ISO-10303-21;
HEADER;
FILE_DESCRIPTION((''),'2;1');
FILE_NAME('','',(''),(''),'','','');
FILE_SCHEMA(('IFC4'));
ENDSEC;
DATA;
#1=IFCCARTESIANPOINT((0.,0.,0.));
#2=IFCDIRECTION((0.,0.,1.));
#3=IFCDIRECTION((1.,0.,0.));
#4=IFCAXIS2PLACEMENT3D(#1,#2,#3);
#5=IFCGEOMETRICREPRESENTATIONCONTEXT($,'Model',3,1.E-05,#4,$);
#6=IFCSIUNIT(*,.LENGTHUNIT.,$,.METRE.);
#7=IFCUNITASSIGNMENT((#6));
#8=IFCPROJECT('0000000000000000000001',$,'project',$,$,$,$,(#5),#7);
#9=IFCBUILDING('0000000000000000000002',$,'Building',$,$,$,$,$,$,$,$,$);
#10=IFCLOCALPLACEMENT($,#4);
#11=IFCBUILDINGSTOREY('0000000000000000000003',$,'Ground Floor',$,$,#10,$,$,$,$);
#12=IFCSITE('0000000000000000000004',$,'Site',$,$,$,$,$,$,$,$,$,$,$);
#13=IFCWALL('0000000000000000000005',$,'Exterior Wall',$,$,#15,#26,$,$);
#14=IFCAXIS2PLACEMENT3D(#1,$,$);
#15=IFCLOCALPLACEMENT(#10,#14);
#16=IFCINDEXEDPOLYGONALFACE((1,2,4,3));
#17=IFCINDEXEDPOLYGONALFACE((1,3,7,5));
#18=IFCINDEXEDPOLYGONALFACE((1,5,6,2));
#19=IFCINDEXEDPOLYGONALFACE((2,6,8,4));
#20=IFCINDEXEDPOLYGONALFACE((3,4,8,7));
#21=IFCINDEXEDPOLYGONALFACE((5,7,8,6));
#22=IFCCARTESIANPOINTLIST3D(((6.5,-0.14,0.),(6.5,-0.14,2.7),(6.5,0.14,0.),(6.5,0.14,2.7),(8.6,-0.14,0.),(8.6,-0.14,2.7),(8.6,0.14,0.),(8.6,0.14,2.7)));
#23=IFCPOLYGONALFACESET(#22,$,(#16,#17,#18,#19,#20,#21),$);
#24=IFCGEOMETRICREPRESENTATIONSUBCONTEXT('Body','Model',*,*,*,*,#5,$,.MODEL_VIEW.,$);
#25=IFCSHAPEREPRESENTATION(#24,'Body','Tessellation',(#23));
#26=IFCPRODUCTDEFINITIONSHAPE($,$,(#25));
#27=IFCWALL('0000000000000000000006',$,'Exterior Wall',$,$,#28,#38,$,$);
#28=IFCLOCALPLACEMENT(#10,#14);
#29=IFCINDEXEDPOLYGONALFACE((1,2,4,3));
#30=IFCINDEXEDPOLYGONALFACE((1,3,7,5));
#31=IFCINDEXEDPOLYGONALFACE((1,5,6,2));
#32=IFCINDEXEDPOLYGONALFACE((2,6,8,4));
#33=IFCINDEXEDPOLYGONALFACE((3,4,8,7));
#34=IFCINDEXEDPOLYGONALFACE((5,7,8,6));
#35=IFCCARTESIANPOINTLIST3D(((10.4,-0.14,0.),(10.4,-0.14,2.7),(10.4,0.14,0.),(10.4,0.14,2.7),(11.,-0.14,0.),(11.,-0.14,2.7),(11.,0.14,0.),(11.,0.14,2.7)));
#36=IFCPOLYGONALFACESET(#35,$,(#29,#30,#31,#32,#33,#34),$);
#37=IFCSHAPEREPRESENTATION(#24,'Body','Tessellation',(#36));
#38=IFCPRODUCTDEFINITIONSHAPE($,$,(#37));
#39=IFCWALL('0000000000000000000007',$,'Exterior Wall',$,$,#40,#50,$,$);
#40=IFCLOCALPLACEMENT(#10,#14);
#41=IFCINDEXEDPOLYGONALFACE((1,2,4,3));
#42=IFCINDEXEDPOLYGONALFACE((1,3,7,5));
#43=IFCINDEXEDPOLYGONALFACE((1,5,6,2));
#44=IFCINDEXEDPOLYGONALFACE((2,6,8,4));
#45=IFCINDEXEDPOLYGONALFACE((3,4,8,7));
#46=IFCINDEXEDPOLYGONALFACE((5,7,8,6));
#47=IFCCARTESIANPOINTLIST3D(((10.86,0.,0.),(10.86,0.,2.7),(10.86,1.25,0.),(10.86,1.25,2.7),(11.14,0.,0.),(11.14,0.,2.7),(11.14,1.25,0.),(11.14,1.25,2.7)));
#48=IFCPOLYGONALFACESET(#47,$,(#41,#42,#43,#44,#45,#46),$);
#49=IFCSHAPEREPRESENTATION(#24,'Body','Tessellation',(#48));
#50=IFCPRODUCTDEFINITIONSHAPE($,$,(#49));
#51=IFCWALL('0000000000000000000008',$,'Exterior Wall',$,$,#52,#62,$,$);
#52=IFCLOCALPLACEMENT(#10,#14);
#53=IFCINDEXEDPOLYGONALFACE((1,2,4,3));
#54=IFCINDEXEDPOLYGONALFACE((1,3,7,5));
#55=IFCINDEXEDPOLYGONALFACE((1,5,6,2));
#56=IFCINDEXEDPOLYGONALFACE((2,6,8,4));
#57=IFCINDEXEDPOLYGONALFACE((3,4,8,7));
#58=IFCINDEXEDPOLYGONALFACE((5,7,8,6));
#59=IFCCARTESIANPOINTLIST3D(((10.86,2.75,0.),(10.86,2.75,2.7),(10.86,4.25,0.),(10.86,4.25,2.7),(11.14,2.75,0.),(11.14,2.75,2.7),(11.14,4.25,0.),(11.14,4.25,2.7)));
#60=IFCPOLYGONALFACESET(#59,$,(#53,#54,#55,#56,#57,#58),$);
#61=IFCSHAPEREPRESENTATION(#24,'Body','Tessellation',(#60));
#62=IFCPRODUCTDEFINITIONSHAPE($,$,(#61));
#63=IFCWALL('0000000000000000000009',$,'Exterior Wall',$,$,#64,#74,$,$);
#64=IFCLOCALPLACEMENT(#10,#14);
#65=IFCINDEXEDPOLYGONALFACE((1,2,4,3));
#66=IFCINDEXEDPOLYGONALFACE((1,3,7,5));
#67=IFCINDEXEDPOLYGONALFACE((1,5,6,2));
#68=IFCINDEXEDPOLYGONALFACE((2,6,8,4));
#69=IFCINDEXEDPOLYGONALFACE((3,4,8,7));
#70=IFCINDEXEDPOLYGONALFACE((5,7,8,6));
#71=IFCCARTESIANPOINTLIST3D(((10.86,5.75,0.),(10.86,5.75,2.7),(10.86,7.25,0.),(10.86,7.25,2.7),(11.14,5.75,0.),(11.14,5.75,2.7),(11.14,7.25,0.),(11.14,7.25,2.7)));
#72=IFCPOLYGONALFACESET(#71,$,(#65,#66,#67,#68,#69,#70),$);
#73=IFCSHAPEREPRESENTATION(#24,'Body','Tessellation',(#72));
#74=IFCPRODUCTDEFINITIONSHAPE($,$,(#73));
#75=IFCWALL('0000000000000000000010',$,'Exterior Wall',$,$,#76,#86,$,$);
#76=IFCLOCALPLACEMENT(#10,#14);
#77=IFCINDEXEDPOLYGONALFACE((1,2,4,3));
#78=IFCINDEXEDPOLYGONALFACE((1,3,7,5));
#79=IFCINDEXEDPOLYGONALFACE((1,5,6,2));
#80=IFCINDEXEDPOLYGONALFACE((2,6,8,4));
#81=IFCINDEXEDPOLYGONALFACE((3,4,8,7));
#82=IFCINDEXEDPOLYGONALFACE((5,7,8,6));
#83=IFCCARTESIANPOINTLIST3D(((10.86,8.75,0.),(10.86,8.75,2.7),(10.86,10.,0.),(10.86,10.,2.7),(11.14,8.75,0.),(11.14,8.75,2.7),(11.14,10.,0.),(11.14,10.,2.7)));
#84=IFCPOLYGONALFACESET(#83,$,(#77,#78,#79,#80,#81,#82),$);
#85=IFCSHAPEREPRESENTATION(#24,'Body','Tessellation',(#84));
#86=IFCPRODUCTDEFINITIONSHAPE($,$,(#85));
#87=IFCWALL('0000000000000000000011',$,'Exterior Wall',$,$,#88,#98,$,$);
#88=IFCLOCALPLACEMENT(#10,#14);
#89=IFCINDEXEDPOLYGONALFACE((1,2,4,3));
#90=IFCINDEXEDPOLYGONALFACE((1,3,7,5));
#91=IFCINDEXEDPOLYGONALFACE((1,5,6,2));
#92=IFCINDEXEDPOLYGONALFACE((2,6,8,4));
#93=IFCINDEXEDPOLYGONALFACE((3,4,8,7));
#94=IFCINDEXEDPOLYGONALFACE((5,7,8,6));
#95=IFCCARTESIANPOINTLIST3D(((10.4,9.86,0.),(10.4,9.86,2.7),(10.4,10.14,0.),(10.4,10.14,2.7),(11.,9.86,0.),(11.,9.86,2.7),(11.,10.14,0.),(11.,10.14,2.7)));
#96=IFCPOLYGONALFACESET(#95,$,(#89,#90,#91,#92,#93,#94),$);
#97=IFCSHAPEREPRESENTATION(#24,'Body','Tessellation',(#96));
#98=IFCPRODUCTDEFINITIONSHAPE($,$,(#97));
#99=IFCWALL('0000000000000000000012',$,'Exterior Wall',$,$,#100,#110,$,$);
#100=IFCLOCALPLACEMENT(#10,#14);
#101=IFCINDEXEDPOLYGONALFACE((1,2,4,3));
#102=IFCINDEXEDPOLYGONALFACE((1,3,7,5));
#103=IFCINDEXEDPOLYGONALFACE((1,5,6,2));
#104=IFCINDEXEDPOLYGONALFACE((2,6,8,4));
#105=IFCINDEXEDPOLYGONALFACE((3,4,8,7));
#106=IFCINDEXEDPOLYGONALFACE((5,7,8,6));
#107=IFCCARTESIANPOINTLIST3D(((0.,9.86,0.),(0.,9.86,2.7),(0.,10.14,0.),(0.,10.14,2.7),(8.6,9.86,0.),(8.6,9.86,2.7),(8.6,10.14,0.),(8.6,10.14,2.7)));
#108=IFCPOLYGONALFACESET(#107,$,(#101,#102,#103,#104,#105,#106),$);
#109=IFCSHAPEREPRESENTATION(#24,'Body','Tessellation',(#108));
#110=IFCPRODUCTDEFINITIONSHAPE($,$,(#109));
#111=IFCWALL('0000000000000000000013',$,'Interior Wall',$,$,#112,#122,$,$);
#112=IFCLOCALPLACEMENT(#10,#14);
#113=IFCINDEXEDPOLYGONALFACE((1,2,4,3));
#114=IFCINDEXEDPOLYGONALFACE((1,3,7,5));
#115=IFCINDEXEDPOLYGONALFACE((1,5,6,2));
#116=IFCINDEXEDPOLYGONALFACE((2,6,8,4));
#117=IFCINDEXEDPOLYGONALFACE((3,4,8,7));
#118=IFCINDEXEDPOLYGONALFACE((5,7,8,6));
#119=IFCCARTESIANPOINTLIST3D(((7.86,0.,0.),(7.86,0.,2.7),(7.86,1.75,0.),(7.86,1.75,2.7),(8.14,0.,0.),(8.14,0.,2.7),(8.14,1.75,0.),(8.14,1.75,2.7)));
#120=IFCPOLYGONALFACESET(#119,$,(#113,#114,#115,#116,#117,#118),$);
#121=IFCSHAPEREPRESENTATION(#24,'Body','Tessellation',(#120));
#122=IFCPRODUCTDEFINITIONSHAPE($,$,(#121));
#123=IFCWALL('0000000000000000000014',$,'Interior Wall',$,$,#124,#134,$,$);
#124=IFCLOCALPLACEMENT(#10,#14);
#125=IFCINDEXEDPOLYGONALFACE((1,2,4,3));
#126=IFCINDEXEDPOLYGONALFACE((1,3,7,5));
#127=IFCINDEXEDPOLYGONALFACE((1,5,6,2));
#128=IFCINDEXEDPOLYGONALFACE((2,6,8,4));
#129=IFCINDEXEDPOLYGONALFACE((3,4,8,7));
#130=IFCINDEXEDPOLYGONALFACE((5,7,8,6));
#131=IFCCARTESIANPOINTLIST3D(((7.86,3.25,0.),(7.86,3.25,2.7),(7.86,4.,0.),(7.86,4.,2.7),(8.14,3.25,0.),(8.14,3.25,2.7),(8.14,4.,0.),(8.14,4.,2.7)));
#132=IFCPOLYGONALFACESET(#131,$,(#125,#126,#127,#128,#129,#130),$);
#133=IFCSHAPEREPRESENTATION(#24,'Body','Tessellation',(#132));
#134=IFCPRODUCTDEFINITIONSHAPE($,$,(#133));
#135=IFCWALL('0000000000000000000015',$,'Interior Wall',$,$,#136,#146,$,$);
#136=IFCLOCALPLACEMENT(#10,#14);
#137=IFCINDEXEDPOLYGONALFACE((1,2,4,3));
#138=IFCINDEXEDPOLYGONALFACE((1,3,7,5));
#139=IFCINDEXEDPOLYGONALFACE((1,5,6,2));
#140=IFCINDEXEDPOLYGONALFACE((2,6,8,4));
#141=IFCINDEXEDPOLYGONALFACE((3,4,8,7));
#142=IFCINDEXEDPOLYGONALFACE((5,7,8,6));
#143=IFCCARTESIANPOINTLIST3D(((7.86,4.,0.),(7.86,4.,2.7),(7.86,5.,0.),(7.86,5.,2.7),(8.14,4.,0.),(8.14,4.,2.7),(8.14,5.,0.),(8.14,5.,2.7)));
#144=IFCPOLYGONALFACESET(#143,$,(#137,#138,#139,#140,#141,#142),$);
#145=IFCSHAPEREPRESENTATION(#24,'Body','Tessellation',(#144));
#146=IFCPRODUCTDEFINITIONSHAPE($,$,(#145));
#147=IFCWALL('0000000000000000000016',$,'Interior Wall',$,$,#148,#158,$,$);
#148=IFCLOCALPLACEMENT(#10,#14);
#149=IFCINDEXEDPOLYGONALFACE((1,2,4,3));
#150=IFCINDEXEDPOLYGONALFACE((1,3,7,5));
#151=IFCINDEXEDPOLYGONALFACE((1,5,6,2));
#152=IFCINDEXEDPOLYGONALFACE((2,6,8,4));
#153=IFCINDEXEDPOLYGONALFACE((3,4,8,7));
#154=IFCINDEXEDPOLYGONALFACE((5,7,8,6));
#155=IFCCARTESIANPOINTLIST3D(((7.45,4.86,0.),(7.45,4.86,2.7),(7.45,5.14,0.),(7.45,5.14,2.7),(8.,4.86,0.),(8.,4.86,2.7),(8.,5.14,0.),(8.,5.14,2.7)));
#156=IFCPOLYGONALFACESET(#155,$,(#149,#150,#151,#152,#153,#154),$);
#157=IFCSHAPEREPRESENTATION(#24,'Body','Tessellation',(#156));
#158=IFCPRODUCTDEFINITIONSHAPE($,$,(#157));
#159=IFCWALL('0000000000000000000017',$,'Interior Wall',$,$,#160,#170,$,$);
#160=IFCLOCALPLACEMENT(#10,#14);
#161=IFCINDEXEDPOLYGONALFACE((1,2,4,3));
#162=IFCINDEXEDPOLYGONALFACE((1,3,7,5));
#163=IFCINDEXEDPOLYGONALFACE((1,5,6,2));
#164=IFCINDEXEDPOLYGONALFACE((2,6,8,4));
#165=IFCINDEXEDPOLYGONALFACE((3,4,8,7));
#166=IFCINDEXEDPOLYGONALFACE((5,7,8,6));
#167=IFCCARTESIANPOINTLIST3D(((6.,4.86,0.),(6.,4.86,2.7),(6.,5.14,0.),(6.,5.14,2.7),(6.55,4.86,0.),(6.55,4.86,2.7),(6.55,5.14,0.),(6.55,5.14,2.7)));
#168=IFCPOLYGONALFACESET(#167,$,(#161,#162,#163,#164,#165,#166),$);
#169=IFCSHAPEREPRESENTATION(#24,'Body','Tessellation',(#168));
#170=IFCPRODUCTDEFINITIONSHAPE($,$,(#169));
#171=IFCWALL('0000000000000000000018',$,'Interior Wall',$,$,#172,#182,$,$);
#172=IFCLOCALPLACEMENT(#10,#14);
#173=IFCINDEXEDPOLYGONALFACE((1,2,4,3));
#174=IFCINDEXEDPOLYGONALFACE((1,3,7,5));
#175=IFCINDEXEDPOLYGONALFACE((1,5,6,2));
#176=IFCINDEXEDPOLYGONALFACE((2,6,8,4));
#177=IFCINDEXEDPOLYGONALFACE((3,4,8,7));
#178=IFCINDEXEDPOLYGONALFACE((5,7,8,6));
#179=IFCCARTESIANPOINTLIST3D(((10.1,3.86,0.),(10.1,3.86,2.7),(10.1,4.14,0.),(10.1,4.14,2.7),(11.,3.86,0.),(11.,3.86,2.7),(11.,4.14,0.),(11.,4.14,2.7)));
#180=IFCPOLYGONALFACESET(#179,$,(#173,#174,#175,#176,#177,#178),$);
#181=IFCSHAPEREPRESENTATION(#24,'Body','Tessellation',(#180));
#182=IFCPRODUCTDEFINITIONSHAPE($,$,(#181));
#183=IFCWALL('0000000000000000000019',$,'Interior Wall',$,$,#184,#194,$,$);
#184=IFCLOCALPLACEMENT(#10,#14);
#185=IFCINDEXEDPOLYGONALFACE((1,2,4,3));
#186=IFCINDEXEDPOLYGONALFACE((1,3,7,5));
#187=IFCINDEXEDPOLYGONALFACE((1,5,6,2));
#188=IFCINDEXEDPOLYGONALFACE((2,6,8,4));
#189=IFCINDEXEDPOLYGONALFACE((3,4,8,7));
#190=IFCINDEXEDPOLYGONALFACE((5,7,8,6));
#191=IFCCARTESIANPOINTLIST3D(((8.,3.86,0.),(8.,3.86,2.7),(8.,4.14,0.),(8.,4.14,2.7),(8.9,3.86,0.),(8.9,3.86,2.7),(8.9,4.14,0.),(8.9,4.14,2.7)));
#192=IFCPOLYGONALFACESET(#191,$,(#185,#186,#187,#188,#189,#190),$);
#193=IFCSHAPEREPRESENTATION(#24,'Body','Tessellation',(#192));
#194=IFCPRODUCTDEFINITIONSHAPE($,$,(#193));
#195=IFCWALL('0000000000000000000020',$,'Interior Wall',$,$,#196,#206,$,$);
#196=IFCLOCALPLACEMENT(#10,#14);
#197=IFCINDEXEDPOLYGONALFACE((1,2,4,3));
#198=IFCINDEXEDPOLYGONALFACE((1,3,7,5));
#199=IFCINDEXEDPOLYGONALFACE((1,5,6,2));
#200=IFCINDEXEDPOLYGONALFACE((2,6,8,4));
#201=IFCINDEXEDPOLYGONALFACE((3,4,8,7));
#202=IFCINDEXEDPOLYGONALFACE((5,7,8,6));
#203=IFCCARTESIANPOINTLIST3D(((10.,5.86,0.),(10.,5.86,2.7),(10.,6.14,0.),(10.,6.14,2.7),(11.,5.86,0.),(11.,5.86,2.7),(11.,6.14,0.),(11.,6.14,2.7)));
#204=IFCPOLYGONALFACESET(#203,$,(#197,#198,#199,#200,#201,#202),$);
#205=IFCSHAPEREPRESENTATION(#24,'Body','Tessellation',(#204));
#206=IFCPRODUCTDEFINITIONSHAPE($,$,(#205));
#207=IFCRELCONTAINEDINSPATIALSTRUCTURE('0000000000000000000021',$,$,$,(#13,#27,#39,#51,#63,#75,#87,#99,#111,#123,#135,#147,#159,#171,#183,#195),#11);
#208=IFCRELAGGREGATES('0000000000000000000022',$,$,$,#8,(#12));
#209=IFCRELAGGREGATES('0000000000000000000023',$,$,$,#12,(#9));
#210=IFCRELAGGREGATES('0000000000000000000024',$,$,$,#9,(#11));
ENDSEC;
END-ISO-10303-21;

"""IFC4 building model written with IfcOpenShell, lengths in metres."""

from ifc_helpers import new_model, si_unit, frame, origin_with_axes, place, context, subcontext, project, spatial, indexed_curve, outline, extrude, element, save


model = new_model("IFC4")

# Units and contexts
model_context = context("Model", 3, precision=1e-05, world=origin_with_axes())
body_context = subcontext(model_context, "Body", "Model", "MODEL_VIEW")
ifc_project = project(units=[si_unit("LENGTHUNIT", "METRE")], contexts=[model_context])

# Site, building, storey
site = spatial("IfcSite", under=ifc_project, Name="Site")
building = spatial("IfcBuilding", under=site, Name="Building")
storey_placement = place(None, origin_with_axes())
storey = spatial("IfcBuildingStorey", under=building, at=storey_placement, Name="Ground Floor")

# Walls
wall_1_placement = place(storey_placement, frame((6.5, 0.0, 0.0), z_axis=(0.0, 0.0, 1.0), x_axis=(1.0, 0.0, 0.0)))
element("IfcWall", 1, at=wall_1_placement, inside=storey, Name="Exterior Wall", context=body_context, shape_type="SweptSolid", body=[
    extrude(outline(indexed_curve([(0.0, 0.0), (0.0, 0.28), (2.1, 0.28), (2.1, 0.0), (0.0, 0.0)], self_intersect=False)), frame((0.0, -0.14, 0.0), z_axis=(0.0, 0.0, 1.0), x_axis=(1.0, 0.0, 0.0)), (0.0, 0.0, 1.0), 2.7),
])
wall_2_placement = place(storey_placement, frame((10.4, 0.0, 0.0), z_axis=(0.0, 0.0, 1.0), x_axis=(1.0, 0.0, 0.0)))
element("IfcWall", 2, at=wall_2_placement, inside=storey, Name="Exterior Wall", context=body_context, shape_type="SweptSolid", body=[
    extrude(outline(indexed_curve([(0.0, 0.0), (0.0, 0.28), (0.6, 0.28), (0.6, 0.0), (0.0, 0.0)], self_intersect=False)), frame((0.0, -0.14, 0.0), z_axis=(0.0, 0.0, 1.0), x_axis=(1.0, 0.0, 0.0)), (0.0, 0.0, 1.0), 2.7),
])
wall_3_placement = place(storey_placement, frame((11.0, 0.0, 0.0), z_axis=(0.0, 0.0, 1.0), x_axis=(0.0, 1.0, 0.0)))
element("IfcWall", 3, at=wall_3_placement, inside=storey, Name="Exterior Wall", context=body_context, shape_type="SweptSolid", body=[
    extrude(outline(indexed_curve([(0.0, 0.0), (0.0, 0.28), (1.25, 0.28), (1.25, 0.0), (0.0, 0.0)], self_intersect=False)), frame((0.0, -0.14, 0.0), z_axis=(0.0, 0.0, 1.0), x_axis=(1.0, 0.0, 0.0)), (0.0, 0.0, 1.0), 2.7),
])
for number, where, z_axis, x_axis, name in (
    (4, (11.0, 2.75, 0.0), (0.0, 0.0, 1.0), (0.0, 1.0, 0.0), "Exterior Wall"),
    (5, (11.0, 5.75, 0.0), (0.0, 0.0, 1.0), (0.0, 1.0, 0.0), "Exterior Wall"),
):
    element("IfcWall", number, at=place(storey_placement, frame(where, z_axis=z_axis, x_axis=x_axis)), inside=storey, Name=name, context=body_context, shape_type="SweptSolid", body=[
        extrude(outline(indexed_curve([(0.0, 0.0), (0.0, 0.28), (1.5, 0.28), (1.5, 0.0), (0.0, 0.0)], self_intersect=False)), frame((0.0, -0.14, 0.0), z_axis=(0.0, 0.0, 1.0), x_axis=(1.0, 0.0, 0.0)), (0.0, 0.0, 1.0), 2.7),
    ])
wall_4_placement = place(storey_placement, frame((11.0, 8.75, 0.0), z_axis=(0.0, 0.0, 1.0), x_axis=(0.0, 1.0, 0.0)))
element("IfcWall", 6, at=wall_4_placement, inside=storey, Name="Exterior Wall", context=body_context, shape_type="SweptSolid", body=[
    extrude(outline(indexed_curve([(0.0, 0.0), (0.0, 0.28), (1.25, 0.28), (1.25, 0.0), (0.0, 0.0)], self_intersect=False)), frame((0.0, -0.14, 0.0), z_axis=(0.0, 0.0, 1.0), x_axis=(1.0, 0.0, 0.0)), (0.0, 0.0, 1.0), 2.7),
])
wall_5_placement = place(storey_placement, frame((11.0, 10.0, 0.0), z_axis=(0.0, 0.0, 1.0), x_axis=(-1.0, 0.0, 0.0)))
element("IfcWall", 7, at=wall_5_placement, inside=storey, Name="Exterior Wall", context=body_context, shape_type="SweptSolid", body=[
    extrude(outline(indexed_curve([(0.0, 0.0), (0.0, 0.28), (0.6, 0.28), (0.6, 0.0), (0.0, 0.0)], self_intersect=False)), frame((0.0, -0.14, 0.0), z_axis=(0.0, 0.0, 1.0), x_axis=(1.0, 0.0, 0.0)), (0.0, 0.0, 1.0), 2.7),
])
wall_6_placement = place(storey_placement, frame((8.6, 10.0, 0.0), z_axis=(0.0, 0.0, 1.0), x_axis=(-1.0, 0.0, 0.0)))
element("IfcWall", 8, at=wall_6_placement, inside=storey, Name="Exterior Wall", context=body_context, shape_type="SweptSolid", body=[
    extrude(outline(indexed_curve([(0.0, 0.0), (0.0, 0.28), (8.6, 0.28), (8.6, 0.0), (0.0, 0.0)], self_intersect=False)), frame((0.0, -0.14, 0.0), z_axis=(0.0, 0.0, 1.0), x_axis=(1.0, 0.0, 0.0)), (0.0, 0.0, 1.0), 2.7),
])
wall_7_placement = place(storey_placement, frame((8.0, 0.0, 0.0), z_axis=(0.0, 0.0, 1.0), x_axis=(0.0, 1.0, 0.0)))
element("IfcWall", 9, at=wall_7_placement, inside=storey, Name="Interior Wall", context=body_context, shape_type="SweptSolid", body=[
    extrude(outline(indexed_curve([(0.0, 0.0), (0.0, 0.28), (1.75, 0.28), (1.75, 0.0), (0.0, 0.0)], self_intersect=False)), frame((0.0, -0.14, 0.0), z_axis=(0.0, 0.0, 1.0), x_axis=(1.0, 0.0, 0.0)), (0.0, 0.0, 1.0), 2.7),
])
wall_8_placement = place(storey_placement, frame((8.0, 3.25, 0.0), z_axis=(0.0, 0.0, 1.0), x_axis=(0.0, 1.0, 0.0)))
element("IfcWall", 10, at=wall_8_placement, inside=storey, Name="Interior Wall", context=body_context, shape_type="SweptSolid", body=[
    extrude(outline(indexed_curve([(0.0, 0.0), (0.0, 0.28), (0.75, 0.28), (0.75, 0.0), (0.0, 0.0)], self_intersect=False)), frame((0.0, -0.14, 0.0), z_axis=(0.0, 0.0, 1.0), x_axis=(1.0, 0.0, 0.0)), (0.0, 0.0, 1.0), 2.7),
])
wall_9_placement = place(storey_placement, frame((8.0, 4.0, 0.0), z_axis=(0.0, 0.0, 1.0), x_axis=(0.0, 1.0, 0.0)))
element("IfcWall", 11, at=wall_9_placement, inside=storey, Name="Interior Wall", context=body_context, shape_type="SweptSolid", body=[
    extrude(outline(indexed_curve([(0.0, 0.0), (0.0, 0.28), (1.0, 0.28), (1.0, 0.0), (0.0, 0.0)], self_intersect=False)), frame((0.0, -0.14, 0.0), z_axis=(0.0, 0.0, 1.0), x_axis=(1.0, 0.0, 0.0)), (0.0, 0.0, 1.0), 2.7),
])
for number, where, z_axis, x_axis, name in (
    (12, (8.0, 5.0, 0.0), (0.0, 0.0, 1.0), (-1.0, 0.0, 0.0), "Interior Wall"),
    (13, (6.55, 5.0, 0.0), (0.0, 0.0, 1.0), (-1.0, 0.0, 0.0), "Interior Wall"),
):
    element("IfcWall", number, at=place(storey_placement, frame(where, z_axis=z_axis, x_axis=x_axis)), inside=storey, Name=name, context=body_context, shape_type="SweptSolid", body=[
        extrude(outline(indexed_curve([(0.0, 0.0), (0.0, 0.28), (0.55, 0.28), (0.55, 0.0), (0.0, 0.0)], self_intersect=False)), frame((0.0, -0.14, 0.0), z_axis=(0.0, 0.0, 1.0), x_axis=(1.0, 0.0, 0.0)), (0.0, 0.0, 1.0), 2.7),
    ])
for number, where, z_axis, x_axis, name in (
    (14, (11.0, 4.0, 0.0), (0.0, 0.0, 1.0), (-1.0, 0.0, 0.0), "Interior Wall"),
    (15, (8.9, 4.0, 0.0), (0.0, 0.0, 1.0), (-1.0, 0.0, 0.0), "Interior Wall"),
):
    element("IfcWall", number, at=place(storey_placement, frame(where, z_axis=z_axis, x_axis=x_axis)), inside=storey, Name=name, context=body_context, shape_type="SweptSolid", body=[
        extrude(outline(indexed_curve([(0.0, 0.0), (0.0, 0.28), (0.9, 0.28), (0.9, 0.0), (0.0, 0.0)], self_intersect=False)), frame((0.0, -0.14, 0.0), z_axis=(0.0, 0.0, 1.0), x_axis=(1.0, 0.0, 0.0)), (0.0, 0.0, 1.0), 2.7),
    ])
for number, where, z_axis, x_axis, name in (
    (16, (11.0, 6.0, 0.0), (0.0, 0.0, 1.0), (-1.0, 0.0, 0.0), "Interior Wall"),
):
    element("IfcWall", number, at=place(storey_placement, frame(where, z_axis=z_axis, x_axis=x_axis)), inside=storey, Name=name, context=body_context, shape_type="SweptSolid", body=[
        extrude(outline(indexed_curve([(0.0, 0.0), (0.0, 0.28), (1.0, 0.28), (1.0, 0.0), (0.0, 0.0)], self_intersect=False)), frame((0.0, -0.14, 0.0), z_axis=(0.0, 0.0, 1.0), x_axis=(1.0, 0.0, 0.0)), (0.0, 0.0, 1.0), 2.7),
    ])

save(model, "model.ifc")
